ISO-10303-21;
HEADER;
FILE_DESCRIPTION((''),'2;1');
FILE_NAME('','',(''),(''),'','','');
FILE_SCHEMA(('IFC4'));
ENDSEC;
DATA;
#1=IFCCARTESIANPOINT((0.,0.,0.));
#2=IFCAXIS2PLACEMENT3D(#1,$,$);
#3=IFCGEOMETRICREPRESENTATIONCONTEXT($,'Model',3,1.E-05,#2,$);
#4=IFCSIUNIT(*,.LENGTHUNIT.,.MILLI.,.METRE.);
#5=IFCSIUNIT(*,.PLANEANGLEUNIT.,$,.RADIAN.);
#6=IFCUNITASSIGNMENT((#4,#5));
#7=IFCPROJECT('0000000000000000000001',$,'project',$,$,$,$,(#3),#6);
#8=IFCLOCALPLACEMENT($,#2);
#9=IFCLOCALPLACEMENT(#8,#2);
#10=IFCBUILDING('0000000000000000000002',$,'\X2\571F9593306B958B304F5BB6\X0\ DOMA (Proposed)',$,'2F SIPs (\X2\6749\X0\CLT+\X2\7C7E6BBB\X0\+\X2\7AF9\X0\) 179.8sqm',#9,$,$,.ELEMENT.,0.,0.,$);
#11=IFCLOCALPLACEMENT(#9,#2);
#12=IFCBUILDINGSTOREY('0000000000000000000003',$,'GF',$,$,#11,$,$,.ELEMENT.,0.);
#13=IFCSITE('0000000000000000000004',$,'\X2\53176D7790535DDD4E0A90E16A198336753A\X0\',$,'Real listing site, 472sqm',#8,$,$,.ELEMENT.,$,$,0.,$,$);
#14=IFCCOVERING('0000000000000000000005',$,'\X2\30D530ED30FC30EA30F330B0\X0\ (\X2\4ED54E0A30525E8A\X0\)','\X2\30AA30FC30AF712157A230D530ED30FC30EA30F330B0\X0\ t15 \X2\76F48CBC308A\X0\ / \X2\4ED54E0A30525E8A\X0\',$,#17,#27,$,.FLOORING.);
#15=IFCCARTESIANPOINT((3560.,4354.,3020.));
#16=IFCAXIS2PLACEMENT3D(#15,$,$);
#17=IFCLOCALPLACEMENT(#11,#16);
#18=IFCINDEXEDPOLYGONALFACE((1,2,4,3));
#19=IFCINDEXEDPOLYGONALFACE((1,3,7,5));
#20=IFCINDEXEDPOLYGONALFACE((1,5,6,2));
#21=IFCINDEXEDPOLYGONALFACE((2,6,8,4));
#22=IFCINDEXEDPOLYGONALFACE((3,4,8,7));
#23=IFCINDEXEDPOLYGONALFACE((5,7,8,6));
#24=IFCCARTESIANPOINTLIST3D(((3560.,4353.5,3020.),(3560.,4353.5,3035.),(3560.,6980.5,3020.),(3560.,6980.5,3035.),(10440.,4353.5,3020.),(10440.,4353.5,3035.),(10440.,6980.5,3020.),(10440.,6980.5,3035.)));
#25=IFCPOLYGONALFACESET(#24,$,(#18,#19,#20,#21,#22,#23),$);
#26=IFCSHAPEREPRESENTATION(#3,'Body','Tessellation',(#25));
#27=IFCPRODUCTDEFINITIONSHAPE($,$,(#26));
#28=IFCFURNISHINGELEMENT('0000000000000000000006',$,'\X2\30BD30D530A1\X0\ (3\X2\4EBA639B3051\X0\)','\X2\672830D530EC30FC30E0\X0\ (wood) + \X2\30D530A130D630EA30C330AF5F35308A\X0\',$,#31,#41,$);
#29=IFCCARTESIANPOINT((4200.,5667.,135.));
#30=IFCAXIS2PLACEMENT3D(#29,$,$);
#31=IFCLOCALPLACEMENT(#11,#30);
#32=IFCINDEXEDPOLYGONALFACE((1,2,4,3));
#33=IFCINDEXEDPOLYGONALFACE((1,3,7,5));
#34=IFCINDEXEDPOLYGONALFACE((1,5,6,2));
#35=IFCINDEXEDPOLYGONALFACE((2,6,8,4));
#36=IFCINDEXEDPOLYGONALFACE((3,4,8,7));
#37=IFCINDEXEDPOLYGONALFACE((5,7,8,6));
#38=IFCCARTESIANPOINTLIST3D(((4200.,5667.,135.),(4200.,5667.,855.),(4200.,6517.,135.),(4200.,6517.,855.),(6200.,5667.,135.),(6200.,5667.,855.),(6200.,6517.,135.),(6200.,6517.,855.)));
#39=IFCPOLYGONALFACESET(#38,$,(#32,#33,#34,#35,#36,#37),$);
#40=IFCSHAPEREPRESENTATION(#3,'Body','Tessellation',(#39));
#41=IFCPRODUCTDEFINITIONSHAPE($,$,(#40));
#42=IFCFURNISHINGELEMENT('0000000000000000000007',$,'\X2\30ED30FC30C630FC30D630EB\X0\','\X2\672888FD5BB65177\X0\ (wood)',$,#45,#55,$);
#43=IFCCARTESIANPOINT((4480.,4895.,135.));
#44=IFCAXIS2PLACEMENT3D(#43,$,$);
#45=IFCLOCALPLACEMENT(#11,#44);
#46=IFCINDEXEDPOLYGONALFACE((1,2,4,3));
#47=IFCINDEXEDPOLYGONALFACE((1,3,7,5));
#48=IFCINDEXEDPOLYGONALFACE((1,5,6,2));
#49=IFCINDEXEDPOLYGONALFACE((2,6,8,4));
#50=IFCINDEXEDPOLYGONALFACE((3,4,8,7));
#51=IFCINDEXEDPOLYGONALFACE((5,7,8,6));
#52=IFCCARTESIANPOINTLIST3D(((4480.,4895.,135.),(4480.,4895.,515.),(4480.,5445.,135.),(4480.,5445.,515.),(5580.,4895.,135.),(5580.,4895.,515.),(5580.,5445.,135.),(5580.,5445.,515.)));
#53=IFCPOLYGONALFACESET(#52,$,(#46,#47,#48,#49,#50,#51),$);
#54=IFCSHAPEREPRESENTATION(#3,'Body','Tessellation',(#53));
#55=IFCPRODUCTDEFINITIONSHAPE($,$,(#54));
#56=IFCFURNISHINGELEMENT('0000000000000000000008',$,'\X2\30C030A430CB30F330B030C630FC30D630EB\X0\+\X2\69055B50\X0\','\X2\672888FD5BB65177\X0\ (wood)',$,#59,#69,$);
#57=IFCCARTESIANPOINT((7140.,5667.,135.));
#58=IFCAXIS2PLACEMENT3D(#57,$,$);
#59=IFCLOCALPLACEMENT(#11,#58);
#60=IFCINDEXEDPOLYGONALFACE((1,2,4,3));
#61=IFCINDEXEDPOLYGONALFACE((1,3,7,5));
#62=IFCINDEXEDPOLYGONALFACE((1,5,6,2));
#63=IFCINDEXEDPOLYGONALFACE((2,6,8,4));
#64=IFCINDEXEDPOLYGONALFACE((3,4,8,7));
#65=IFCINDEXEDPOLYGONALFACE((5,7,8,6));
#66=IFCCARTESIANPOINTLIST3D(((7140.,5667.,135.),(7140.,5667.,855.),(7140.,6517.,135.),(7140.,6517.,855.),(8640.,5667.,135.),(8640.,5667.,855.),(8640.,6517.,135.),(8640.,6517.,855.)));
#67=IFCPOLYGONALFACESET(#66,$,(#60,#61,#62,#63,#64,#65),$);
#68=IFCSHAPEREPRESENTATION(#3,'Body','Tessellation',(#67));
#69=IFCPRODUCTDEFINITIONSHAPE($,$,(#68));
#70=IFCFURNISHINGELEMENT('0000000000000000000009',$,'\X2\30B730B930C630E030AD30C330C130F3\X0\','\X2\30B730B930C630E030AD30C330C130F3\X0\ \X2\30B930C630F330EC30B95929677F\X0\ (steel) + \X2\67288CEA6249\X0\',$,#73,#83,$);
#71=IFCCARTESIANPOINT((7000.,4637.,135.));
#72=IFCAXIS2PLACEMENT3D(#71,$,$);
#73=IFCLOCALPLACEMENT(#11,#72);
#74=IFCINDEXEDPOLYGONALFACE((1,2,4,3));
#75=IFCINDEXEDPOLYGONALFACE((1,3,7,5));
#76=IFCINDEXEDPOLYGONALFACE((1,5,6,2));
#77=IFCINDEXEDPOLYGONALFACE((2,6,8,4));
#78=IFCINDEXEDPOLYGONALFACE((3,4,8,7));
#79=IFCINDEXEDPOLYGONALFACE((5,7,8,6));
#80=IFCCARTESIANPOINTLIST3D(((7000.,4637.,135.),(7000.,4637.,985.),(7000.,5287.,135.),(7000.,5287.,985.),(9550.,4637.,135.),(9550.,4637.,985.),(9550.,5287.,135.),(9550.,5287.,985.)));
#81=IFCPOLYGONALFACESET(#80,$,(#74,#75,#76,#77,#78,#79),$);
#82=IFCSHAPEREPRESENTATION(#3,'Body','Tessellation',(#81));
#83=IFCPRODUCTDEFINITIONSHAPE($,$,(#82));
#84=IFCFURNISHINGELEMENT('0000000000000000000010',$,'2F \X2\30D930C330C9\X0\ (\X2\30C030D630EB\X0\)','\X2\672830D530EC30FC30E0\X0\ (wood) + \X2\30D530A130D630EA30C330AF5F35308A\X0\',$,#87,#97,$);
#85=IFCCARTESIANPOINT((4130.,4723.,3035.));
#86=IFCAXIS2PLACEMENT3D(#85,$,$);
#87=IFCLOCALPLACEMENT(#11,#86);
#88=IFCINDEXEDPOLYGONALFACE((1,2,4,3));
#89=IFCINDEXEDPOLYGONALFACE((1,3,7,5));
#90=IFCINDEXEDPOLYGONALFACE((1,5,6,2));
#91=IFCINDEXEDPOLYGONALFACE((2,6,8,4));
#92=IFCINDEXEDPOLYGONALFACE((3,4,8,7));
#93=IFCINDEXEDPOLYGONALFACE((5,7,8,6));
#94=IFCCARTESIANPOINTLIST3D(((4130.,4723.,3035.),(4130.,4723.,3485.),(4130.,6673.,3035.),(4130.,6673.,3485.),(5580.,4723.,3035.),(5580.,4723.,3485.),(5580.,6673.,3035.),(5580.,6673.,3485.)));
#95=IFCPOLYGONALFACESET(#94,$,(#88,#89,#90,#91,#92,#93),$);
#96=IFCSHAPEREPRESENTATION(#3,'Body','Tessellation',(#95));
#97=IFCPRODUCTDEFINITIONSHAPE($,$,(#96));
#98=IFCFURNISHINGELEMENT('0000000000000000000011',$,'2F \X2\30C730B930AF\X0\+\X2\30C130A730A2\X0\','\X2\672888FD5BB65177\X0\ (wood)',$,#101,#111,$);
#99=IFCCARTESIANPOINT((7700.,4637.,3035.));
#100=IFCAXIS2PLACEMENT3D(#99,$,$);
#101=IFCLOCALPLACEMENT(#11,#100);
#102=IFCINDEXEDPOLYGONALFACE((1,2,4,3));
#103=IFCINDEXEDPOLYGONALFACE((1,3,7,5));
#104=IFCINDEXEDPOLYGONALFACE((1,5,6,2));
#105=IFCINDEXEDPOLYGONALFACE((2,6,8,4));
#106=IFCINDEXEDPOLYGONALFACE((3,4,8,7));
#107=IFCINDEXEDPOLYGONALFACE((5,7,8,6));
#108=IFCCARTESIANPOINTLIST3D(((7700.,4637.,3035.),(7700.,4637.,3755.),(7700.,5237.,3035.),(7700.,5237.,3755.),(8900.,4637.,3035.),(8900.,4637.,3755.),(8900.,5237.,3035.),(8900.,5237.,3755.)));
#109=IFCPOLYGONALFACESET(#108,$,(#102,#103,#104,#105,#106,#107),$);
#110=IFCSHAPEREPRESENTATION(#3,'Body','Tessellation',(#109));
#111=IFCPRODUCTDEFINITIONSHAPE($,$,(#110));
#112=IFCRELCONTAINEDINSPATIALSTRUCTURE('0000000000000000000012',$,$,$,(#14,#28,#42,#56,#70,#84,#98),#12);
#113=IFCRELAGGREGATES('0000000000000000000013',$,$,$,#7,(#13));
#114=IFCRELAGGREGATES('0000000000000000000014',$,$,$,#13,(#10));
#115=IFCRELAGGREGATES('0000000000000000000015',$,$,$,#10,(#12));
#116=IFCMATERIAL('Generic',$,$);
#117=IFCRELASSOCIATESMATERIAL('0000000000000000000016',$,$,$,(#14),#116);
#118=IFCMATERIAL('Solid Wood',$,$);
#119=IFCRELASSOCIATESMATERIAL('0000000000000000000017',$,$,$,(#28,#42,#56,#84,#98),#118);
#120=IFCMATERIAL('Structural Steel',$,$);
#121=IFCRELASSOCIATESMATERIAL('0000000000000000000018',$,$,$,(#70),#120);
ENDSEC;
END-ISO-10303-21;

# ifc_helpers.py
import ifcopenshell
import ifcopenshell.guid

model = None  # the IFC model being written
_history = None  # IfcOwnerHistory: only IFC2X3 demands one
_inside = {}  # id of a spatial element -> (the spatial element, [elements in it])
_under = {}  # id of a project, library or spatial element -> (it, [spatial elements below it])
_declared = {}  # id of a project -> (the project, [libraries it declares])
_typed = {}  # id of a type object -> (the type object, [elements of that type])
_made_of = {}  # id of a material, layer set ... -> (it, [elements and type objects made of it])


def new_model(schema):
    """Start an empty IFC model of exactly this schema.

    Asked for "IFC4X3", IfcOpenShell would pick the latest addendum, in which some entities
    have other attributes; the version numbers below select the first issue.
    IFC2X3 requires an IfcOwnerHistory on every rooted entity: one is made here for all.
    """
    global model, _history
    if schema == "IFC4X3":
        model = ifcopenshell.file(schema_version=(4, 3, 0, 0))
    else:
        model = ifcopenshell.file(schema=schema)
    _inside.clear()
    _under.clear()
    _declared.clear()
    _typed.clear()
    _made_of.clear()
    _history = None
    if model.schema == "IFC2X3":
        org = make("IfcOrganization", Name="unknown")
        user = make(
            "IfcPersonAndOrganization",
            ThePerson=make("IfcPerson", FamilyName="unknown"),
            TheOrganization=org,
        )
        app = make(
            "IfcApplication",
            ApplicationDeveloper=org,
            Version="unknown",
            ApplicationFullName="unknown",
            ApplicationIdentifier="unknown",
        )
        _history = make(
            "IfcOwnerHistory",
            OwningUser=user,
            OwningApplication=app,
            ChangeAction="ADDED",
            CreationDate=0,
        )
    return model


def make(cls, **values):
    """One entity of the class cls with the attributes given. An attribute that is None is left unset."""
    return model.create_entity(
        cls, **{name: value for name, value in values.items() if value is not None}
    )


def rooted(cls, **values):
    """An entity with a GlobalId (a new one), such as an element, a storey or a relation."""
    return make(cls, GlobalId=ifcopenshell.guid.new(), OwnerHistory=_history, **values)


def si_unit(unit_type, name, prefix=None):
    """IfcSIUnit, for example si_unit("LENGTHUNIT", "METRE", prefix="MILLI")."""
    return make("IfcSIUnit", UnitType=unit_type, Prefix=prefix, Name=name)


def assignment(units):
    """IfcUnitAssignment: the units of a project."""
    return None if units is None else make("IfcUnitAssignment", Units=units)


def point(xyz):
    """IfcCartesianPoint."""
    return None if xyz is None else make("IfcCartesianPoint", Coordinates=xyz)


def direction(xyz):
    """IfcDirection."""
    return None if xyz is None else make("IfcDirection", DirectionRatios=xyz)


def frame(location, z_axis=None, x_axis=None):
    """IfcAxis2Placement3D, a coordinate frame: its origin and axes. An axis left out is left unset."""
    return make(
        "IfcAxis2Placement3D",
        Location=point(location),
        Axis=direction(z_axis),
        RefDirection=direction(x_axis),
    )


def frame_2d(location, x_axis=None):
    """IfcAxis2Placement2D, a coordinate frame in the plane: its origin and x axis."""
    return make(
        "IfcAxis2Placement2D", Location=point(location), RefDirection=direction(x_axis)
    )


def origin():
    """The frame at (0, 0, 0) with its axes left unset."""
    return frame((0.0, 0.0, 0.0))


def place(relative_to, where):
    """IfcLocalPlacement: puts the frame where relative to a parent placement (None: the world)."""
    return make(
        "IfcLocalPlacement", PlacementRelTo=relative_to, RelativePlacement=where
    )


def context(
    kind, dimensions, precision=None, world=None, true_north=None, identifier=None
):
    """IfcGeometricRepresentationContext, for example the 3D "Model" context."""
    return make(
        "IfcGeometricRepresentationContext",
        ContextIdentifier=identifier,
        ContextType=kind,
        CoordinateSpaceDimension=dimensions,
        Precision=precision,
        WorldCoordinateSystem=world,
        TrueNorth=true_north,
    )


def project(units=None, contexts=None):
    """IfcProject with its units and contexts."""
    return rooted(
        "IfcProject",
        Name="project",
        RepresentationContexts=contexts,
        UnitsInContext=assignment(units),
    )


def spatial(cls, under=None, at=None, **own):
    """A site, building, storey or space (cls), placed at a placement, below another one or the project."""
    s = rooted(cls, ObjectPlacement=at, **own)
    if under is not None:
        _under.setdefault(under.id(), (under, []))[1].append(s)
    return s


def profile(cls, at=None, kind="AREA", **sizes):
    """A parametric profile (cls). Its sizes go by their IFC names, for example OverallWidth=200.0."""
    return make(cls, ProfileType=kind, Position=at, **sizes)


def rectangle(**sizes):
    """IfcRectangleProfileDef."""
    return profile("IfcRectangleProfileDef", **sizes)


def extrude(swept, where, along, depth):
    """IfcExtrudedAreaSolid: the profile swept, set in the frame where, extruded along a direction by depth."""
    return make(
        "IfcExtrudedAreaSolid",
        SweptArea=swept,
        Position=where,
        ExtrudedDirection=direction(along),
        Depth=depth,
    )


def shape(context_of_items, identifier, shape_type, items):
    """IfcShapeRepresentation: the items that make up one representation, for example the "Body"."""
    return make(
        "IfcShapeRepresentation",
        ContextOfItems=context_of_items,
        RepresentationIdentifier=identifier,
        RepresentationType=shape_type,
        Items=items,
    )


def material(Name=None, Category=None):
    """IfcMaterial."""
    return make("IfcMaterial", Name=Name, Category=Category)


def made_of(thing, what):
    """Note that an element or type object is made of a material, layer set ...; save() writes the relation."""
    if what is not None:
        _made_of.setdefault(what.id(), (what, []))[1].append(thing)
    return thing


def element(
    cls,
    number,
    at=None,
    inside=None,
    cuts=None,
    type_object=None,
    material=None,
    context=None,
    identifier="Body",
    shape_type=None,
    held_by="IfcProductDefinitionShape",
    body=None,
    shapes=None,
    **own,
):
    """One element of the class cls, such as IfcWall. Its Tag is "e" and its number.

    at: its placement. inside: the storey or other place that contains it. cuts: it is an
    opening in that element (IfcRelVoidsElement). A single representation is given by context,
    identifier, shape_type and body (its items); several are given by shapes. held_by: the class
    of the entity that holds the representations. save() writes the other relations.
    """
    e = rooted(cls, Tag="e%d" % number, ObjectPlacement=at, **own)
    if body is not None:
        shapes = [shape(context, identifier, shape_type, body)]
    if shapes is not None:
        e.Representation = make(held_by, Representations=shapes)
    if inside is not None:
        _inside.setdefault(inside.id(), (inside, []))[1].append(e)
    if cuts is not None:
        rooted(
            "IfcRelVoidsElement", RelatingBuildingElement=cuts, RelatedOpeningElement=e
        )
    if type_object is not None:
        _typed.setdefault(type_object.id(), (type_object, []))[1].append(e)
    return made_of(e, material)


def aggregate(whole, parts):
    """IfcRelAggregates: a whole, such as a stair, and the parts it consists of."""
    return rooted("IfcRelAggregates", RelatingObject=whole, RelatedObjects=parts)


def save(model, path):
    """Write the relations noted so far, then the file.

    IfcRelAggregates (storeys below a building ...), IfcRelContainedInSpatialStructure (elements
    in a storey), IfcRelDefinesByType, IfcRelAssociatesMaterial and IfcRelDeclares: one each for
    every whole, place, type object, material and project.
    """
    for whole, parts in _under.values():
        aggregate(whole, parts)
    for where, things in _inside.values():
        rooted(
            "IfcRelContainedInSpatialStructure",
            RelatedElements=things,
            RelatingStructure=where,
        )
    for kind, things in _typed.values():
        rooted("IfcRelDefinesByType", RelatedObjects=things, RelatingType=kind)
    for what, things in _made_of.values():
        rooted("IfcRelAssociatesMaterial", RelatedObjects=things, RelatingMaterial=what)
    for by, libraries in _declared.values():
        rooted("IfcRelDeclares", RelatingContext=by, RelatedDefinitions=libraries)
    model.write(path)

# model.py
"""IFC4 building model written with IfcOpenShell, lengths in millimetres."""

from ifc_helpers import new_model, si_unit, frame, frame_2d, origin, place, context, project, spatial, rectangle, extrude, material, element, save


model = new_model("IFC4")

# Units and contexts
model_context = context("Model", 3, precision=1e-05, world=origin())
ifc_project = project(units=[si_unit("LENGTHUNIT", "METRE", prefix="MILLI"), si_unit("PLANEANGLEUNIT", "RADIAN")], contexts=[model_context])

# Site, building, storey
site_placement = place(None, origin())
site = spatial("IfcSite", under=ifc_project, at=site_placement, Name="北海道川上郡標茶町", ObjectType="Real listing site, 472sqm", CompositionType="ELEMENT", RefElevation=0.0)
building_placement = place(site_placement, origin())
building = spatial("IfcBuilding", under=site, at=building_placement, Name="土間に開く家 DOMA (Proposed)", ObjectType="2F SIPs (杉CLT+籾殻+竹) 179.8sqm", CompositionType="ELEMENT", ElevationOfRefHeight=0.0, ElevationOfTerrain=0.0)
storey_placement = place(building_placement, origin())
storey = spatial("IfcBuildingStorey", under=building, at=storey_placement, Name="GF", CompositionType="ELEMENT", Elevation=0.0)

# Shared definitions
ifc_material_1 = material(Name="Solid Wood")

# Shared definitions
ifc_material_2 = material(Name="Generic")

# Shared definitions
ifc_material_3 = material(Name="Structural Steel")

# Covering
covering_placement = place(storey_placement, frame((3560.0, 4354.0, 3020.0)))
element("IfcCovering", 1, at=covering_placement, inside=storey, material=ifc_material_2, Name="フローリング (仕上げ床)", Description="オーク無垢フローリング t15 直貼り / 仕上げ床", PredefinedType="FLOORING", context=model_context, shape_type="SweptSolid", body=[
    extrude(rectangle(XDim=6880.0, YDim=2627.0, at=frame_2d((3440.0, 1313.0))), frame((3560.0, 4354.0, 3020.0)), (0.0, 0.0, 1.0), 15.0),
])

# Furnishing elements
furnishing_1_placement = place(storey_placement, frame((4200.0, 5667.0, 135.0)))
element("IfcFurnishingElement", 2, at=furnishing_1_placement, inside=storey, material=ifc_material_1, Name="ソファ (3人掛け)", Description="木フレーム (wood) + ファブリック張り", context=model_context, shape_type="SweptSolid", body=[
    extrude(rectangle(XDim=2000.0, YDim=850.0, at=frame_2d((1000.0, 425.0))), frame((4200.0, 5667.0, 135.0)), (0.0, 0.0, 1.0), 720.0),
])
furnishing_2_placement = place(storey_placement, frame((4480.0, 4895.0, 135.0)))
element("IfcFurnishingElement", 3, at=furnishing_2_placement, inside=storey, material=ifc_material_1, Name="ローテーブル", Description="木製家具 (wood)", context=model_context, shape_type="SweptSolid", body=[
    extrude(rectangle(XDim=1100.0, YDim=550.0, at=frame_2d((550.0, 275.0))), frame((4480.0, 4895.0, 135.0)), (0.0, 0.0, 1.0), 380.0),
])
furnishing_3_placement = place(storey_placement, frame((7140.0, 5667.0, 135.0)))
element("IfcFurnishingElement", 4, at=furnishing_3_placement, inside=storey, material=ifc_material_1, Name="ダイニングテーブル+椅子", Description="木製家具 (wood)", context=model_context, shape_type="SweptSolid", body=[
    extrude(rectangle(XDim=1500.0, YDim=850.0, at=frame_2d((750.0, 425.0))), frame((7140.0, 5667.0, 135.0)), (0.0, 0.0, 1.0), 720.0),
])
furnishing_4_placement = place(storey_placement, frame((7000.0, 4637.0, 135.0)))
element("IfcFurnishingElement", 5, at=furnishing_4_placement, inside=storey, material=ifc_material_3, Name="システムキッチン", Description="システムキッチン ステンレス天板 (steel) + 木質扉", context=model_context, shape_type="SweptSolid", body=[
    extrude(rectangle(XDim=2550.0, YDim=650.0, at=frame_2d((1275.0, 325.0))), frame((7000.0, 4637.0, 135.0)), (0.0, 0.0, 1.0), 850.0),
])
furnishing_5_placement = place(storey_placement, frame((4130.0, 4723.0, 3035.0)))
element("IfcFurnishingElement", 6, at=furnishing_5_placement, inside=storey, material=ifc_material_1, Name="2F ベッド (ダブル)", Description="木フレーム (wood) + ファブリック張り", context=model_context, shape_type="SweptSolid", body=[
    extrude(rectangle(XDim=1450.0, YDim=1950.0, at=frame_2d((725.0, 975.0))), frame((4130.0, 4723.0, 3035.0)), (0.0, 0.0, 1.0), 450.0),
])
furnishing_6_placement = place(storey_placement, frame((7700.0, 4637.0, 3035.0)))
element("IfcFurnishingElement", 7, at=furnishing_6_placement, inside=storey, material=ifc_material_1, Name="2F デスク+チェア", Description="木製家具 (wood)", context=model_context, shape_type="SweptSolid", body=[
    extrude(rectangle(XDim=1200.0, YDim=600.0, at=frame_2d((600.0, 300.0))), frame((7700.0, 4637.0, 3035.0)), (0.0, 0.0, 1.0), 720.0),
])

save(model, "model.ifc")
